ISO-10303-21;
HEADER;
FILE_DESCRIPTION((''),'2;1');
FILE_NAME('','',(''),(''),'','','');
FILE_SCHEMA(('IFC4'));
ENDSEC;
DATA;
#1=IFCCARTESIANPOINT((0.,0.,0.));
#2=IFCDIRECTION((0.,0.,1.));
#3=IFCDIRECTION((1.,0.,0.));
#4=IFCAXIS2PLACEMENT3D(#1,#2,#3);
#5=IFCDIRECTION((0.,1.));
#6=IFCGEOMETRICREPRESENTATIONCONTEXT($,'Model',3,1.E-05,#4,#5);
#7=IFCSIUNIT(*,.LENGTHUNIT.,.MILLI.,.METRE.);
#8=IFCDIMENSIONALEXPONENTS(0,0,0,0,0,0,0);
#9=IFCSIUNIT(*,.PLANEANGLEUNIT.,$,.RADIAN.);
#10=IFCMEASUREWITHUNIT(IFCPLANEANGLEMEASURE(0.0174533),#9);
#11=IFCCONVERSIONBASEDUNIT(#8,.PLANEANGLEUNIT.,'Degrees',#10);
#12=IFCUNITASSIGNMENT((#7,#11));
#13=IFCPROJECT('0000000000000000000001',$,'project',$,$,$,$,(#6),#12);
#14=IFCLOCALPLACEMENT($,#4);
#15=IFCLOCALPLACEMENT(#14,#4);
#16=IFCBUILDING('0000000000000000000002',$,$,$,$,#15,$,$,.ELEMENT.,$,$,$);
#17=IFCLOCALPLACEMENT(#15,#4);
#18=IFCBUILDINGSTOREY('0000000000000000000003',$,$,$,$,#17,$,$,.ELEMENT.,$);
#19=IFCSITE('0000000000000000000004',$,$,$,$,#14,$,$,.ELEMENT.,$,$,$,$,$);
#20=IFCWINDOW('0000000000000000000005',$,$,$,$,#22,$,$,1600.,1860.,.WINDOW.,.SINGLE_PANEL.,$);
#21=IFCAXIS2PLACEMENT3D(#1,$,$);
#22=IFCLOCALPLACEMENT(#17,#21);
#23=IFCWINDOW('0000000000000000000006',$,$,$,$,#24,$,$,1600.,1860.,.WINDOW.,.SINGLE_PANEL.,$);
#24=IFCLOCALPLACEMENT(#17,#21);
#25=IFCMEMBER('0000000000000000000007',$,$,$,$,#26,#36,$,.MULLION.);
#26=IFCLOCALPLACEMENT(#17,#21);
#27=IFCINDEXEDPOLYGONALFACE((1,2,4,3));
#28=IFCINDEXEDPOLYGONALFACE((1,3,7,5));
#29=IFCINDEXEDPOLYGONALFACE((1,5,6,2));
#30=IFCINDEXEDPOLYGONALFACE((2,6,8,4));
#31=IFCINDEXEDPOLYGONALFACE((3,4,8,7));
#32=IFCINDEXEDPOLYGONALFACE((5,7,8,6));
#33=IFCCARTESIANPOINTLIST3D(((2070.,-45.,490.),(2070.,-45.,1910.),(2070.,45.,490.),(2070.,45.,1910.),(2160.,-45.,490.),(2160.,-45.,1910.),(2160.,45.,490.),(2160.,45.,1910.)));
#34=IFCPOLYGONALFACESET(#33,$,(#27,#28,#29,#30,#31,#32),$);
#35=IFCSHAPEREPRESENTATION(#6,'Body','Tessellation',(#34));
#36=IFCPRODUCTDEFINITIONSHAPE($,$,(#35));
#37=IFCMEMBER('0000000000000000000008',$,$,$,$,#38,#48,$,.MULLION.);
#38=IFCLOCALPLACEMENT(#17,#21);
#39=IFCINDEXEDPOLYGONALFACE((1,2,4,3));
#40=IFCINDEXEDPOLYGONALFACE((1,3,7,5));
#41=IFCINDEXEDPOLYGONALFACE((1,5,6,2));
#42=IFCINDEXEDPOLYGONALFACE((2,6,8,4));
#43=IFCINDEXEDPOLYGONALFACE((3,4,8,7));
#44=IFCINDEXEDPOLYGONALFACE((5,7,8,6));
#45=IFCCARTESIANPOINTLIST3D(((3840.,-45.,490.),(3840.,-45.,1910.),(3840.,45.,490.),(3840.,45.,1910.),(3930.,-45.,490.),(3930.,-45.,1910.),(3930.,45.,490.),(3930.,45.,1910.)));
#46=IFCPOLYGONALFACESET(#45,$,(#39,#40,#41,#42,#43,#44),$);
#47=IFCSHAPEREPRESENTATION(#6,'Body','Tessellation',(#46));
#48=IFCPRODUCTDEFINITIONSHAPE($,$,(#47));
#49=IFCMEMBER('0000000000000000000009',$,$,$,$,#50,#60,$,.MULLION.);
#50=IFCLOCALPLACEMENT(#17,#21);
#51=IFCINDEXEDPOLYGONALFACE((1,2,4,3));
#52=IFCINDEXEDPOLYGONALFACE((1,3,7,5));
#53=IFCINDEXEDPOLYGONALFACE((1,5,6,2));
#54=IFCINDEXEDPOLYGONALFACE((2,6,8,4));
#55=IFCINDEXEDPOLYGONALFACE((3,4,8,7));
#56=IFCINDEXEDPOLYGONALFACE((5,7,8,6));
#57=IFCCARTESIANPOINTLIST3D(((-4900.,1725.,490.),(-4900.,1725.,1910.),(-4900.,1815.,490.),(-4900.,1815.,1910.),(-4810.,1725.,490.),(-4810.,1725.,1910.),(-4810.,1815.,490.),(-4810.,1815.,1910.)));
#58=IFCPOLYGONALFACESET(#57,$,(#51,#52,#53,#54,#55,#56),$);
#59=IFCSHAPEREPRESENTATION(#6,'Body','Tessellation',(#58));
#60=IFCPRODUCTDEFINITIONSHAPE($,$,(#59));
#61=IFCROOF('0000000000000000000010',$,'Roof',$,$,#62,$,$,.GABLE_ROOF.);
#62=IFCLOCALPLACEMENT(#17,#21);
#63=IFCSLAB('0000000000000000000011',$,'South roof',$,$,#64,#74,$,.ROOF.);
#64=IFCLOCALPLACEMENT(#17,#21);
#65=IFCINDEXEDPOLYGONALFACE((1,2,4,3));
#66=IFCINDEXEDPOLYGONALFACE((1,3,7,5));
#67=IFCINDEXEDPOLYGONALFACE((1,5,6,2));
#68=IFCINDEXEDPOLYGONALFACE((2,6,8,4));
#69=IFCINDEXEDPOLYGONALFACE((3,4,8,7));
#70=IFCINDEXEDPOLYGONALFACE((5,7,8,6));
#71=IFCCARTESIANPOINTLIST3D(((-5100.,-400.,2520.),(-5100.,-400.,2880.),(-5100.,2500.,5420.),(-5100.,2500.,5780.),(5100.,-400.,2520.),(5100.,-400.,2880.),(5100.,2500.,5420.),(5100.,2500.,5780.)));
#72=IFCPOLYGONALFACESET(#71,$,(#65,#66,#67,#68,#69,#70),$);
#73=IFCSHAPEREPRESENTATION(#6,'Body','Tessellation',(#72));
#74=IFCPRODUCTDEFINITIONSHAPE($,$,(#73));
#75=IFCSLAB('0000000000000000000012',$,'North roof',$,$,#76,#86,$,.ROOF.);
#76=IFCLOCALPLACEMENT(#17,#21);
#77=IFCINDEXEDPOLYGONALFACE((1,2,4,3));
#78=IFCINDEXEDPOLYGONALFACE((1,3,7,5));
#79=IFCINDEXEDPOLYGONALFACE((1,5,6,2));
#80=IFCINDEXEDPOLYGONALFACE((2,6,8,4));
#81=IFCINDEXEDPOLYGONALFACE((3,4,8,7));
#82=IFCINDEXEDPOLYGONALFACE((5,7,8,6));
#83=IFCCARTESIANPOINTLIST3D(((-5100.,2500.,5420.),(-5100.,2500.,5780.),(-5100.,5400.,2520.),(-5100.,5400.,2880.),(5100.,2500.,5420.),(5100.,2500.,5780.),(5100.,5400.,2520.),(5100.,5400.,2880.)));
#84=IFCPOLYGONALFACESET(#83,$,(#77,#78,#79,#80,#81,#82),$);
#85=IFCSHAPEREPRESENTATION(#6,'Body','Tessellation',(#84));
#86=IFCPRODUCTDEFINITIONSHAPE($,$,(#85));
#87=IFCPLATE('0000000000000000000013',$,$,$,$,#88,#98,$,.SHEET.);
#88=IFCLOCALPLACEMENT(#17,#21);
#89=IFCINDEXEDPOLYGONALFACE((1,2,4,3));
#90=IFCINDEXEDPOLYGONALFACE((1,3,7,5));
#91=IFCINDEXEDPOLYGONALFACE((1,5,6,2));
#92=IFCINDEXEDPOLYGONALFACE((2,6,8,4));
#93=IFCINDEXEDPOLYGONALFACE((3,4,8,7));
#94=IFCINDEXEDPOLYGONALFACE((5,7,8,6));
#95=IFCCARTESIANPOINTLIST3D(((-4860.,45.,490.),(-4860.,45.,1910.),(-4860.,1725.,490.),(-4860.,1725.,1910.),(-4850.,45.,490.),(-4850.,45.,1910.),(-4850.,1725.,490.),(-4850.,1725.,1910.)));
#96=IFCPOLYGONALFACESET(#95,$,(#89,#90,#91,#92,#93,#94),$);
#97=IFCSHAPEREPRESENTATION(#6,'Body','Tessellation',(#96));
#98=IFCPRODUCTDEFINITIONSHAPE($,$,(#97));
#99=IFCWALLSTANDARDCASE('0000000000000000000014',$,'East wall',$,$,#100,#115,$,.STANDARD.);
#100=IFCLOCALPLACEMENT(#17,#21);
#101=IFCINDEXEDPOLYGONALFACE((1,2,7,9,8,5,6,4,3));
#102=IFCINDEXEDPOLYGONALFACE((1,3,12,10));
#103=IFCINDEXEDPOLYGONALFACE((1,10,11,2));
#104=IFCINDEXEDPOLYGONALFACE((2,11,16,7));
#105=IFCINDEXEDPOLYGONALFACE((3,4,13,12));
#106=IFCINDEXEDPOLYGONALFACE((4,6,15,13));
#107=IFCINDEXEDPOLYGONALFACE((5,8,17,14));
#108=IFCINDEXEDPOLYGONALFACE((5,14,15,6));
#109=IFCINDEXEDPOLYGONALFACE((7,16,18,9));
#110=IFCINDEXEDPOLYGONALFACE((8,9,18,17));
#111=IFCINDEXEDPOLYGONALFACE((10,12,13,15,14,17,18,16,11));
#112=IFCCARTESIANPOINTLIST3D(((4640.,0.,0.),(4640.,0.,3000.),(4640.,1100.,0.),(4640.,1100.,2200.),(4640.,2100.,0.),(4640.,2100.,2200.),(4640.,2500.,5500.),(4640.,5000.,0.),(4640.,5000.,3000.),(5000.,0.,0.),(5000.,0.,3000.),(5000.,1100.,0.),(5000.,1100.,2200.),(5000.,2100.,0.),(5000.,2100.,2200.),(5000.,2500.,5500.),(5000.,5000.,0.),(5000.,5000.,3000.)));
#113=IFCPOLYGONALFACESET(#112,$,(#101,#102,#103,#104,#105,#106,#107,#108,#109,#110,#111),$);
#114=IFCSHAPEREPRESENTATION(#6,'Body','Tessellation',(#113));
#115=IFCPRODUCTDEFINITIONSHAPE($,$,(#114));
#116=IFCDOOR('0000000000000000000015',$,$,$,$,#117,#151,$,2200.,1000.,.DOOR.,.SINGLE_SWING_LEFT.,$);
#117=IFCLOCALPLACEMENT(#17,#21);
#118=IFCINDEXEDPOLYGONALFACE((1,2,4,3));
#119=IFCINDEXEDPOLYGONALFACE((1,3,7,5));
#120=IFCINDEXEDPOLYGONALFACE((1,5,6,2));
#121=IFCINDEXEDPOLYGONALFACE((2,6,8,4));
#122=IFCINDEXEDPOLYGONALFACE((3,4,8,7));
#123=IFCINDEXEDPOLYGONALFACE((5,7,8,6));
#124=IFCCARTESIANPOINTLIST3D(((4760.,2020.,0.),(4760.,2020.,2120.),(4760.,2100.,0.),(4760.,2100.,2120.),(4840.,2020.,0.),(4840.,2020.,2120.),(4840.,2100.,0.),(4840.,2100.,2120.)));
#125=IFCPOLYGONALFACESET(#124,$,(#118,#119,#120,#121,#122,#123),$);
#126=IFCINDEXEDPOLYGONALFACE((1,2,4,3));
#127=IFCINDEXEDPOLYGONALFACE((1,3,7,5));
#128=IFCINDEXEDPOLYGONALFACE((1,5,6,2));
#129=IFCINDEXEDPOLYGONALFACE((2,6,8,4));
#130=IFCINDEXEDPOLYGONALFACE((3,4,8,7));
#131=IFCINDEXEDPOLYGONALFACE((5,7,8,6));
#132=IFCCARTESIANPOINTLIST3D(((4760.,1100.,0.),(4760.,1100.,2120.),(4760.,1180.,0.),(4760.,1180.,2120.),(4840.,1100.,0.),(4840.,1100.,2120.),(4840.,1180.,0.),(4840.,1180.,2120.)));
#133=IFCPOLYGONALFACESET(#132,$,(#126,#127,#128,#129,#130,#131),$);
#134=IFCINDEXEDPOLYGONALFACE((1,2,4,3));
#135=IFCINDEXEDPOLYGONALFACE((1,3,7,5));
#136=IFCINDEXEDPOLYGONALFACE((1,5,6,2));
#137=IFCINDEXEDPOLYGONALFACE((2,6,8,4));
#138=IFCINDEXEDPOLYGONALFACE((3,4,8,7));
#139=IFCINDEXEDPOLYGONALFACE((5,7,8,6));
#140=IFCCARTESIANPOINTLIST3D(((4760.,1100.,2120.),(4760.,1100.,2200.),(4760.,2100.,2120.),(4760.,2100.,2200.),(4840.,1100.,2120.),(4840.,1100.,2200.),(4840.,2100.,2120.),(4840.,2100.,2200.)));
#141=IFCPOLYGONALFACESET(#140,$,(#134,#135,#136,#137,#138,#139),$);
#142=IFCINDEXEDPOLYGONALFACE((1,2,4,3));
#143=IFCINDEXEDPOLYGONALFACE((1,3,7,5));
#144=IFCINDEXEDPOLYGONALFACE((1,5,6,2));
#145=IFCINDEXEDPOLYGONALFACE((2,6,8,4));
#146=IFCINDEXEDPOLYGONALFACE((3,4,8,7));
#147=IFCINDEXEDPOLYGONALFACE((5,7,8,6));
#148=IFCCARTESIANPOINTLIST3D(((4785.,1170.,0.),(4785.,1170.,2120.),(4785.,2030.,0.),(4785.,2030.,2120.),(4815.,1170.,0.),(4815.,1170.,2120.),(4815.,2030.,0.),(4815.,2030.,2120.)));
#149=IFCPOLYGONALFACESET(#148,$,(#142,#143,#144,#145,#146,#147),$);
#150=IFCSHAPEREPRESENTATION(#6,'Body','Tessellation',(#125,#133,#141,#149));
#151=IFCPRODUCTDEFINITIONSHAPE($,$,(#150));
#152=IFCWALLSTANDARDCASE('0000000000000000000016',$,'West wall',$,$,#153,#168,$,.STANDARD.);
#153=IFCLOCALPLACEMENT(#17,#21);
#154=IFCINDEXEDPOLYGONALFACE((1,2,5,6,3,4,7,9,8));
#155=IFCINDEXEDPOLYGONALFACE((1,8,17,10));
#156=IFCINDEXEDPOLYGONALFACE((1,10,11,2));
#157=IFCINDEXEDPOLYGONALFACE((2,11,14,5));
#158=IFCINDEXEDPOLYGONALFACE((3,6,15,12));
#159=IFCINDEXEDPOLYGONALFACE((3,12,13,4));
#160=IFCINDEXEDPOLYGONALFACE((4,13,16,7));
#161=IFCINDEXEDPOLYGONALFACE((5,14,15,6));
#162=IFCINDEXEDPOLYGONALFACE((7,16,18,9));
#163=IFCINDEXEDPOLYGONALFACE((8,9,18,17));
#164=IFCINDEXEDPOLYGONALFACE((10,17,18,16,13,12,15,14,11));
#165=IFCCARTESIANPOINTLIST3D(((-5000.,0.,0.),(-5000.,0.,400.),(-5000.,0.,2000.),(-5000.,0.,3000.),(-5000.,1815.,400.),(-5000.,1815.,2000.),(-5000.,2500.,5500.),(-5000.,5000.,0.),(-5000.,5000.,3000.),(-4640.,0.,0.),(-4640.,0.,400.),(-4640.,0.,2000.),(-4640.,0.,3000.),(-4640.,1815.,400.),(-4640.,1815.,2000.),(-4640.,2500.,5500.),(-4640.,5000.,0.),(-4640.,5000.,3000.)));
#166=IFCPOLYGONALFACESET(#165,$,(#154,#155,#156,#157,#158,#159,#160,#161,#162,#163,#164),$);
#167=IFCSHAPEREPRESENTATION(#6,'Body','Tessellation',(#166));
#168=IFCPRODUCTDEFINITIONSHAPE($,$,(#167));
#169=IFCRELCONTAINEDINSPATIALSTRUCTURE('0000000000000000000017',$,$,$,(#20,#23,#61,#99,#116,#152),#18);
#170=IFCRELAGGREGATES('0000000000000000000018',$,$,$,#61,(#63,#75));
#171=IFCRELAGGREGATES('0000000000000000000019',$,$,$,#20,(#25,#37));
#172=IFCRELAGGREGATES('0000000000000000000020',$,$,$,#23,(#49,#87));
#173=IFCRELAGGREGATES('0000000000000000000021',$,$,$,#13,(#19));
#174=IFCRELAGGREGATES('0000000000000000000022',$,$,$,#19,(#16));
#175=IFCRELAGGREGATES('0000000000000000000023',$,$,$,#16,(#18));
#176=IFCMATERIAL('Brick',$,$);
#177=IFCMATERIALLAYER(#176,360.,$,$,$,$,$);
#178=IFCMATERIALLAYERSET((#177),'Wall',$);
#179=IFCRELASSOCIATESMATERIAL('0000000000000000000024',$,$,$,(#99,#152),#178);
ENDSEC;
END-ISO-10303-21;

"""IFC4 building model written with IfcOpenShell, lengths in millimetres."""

from ifc_helpers import new_model, entity, si_unit, converted_unit, direction, frame, origin_with_axes, place, context, project, spatial, polyline, outline, extrude, clip, halfspace, source, transform, mapped, material, layer, layer_set, layer_usage, element, fill, aggregate, save


model = new_model("IFC4")

# Units and contexts
model_context = context("Model", 3, precision=1e-05, world=origin_with_axes(), true_north=direction((0.0, 1.0)))
ifc_project = project(units=[si_unit("LENGTHUNIT", "METRE", prefix="MILLI"), converted_unit("PLANEANGLEUNIT", "Degrees", entity("IfcPlaneAngleMeasure", 0.0174533), si_unit("PLANEANGLEUNIT", "RADIAN"), dimensions=[0, 0, 0, 0, 0, 0, 0])], contexts=[model_context])

# Site, building, storey
site_placement = place(None, origin_with_axes())
site = spatial("IfcSite", under=ifc_project, at=site_placement, CompositionType="ELEMENT")
building_placement = place(site_placement, origin_with_axes())
building = spatial("IfcBuilding", under=site, at=building_placement, CompositionType="ELEMENT")
storey_placement = place(building_placement, origin_with_axes())
storey = spatial("IfcBuildingStorey", under=building, at=storey_placement, CompositionType="ELEMENT")

# Windows
window_1_placement = place(storey_placement, frame((2070.0, -45.0, 400.0), z_axis=(0.0, 0.0, 1.0), x_axis=(1.0, 0.0, 0.0)))
window_1 = element("IfcWindow", 1, at=window_1_placement, inside=storey, OverallHeight=1600.0, OverallWidth=1860.0, PartitioningType="SINGLE_PANEL", PredefinedType="WINDOW")
window_2_placement = place(storey_placement, frame((-4810.0, -45.0, 400.0), z_axis=(0.0, 0.0, 1.0), x_axis=(0.0, 1.0, 0.0)))
window_2 = element("IfcWindow", 2, at=window_2_placement, inside=storey, OverallHeight=1600.0, OverallWidth=1860.0, PartitioningType="SINGLE_PANEL", PredefinedType="WINDOW")

# Members
shared_shape_1 = source(origin_with_axes(), model_context, "Body", "SweptSolid", [
    extrude(outline(polyline([(-45.0, -45.0), (45.0, -45.0), (45.0, 45.0), (-45.0, 45.0), (-45.0, -45.0), (-45.0, -45.0)])), origin_with_axes(), (0.0, 0.0, 1.0), 1420.0),
])
member_1_placement = place(window_1_placement, frame((45.0, 45.0, 90.0), z_axis=(0.0, 0.0, 1.0), x_axis=(1.0, 0.0, 0.0)))
member_1 = element("IfcMember", 3, at=member_1_placement, PredefinedType="MULLION", context=model_context, shape_type="MappedRepresentation", body=[
    mapped(shared_shape_1, transform((0.0, 0.0, 0.0))),
])
member_2_placement = place(window_1_placement, frame((1815.0, 45.0, 90.0), z_axis=(0.0, 0.0, 1.0), x_axis=(1.0, 0.0, 0.0)))
member_2 = element("IfcMember", 4, at=member_2_placement, PredefinedType="MULLION", context=model_context, shape_type="MappedRepresentation", body=[
    mapped(shared_shape_1, transform((0.0, 0.0, 0.0))),
])
member_3_placement = place(window_2_placement, frame((1815.0, 45.0, 90.0), z_axis=(0.0, 0.0, 1.0), x_axis=(1.0, 0.0, 0.0)))
member_3 = element("IfcMember", 5, at=member_3_placement, PredefinedType="MULLION", context=model_context, shape_type="MappedRepresentation", body=[
    mapped(shared_shape_1, transform((0.0, 0.0, 0.0))),
])

# Roof, slabs
roof_placement = place(storey_placement, origin_with_axes())
roof = element("IfcRoof", 6, at=roof_placement, inside=storey, Name="Roof", PredefinedType="GABLE_ROOF")
shared_shape_2 = source(origin_with_axes(), model_context, "Body", "SweptSolid", [
    extrude(outline(polyline([(-5100.0, -180.0), (5100.0, -180.0), (5100.0, 180.0), (-5100.0, 180.0), (-5100.0, -180.0), (-5100.0, -180.0)])), frame((0.0, 0.0, 0.0), z_axis=(0.0, 1.0, 0.0), x_axis=(1.0, 0.0, 0.0)), (0.0, -0.707107, 0.707107), 4101.2),
])
slab_1_placement = place(roof_placement, frame((0.0, -400.0, 2700.0), z_axis=(0.0, 0.0, 1.0), x_axis=(1.0, 0.0, 0.0)))
slab_1 = element("IfcSlab", 7, at=slab_1_placement, Name="South roof", PredefinedType="ROOF", context=model_context, shape_type="MappedRepresentation", body=[
    mapped(shared_shape_2, transform((0.0, 0.0, 0.0))),
])
slab_2_placement = place(roof_placement, frame((0.0, 5400.0, 2700.0), z_axis=(0.0, 0.0, 1.0), x_axis=(-1.0, 0.0, 0.0)))
slab_2 = element("IfcSlab", 8, at=slab_2_placement, Name="North roof", PredefinedType="ROOF", context=model_context, shape_type="MappedRepresentation", body=[
    mapped(shared_shape_2, transform((0.0, 0.0, 0.0))),
])
aggregate(roof, [slab_1, slab_2])

# Plate
aggregate(window_1, [member_1, member_2])
plate_1_placement = place(window_2_placement, frame((930.0, 45.0, 90.0), z_axis=(0.0, 0.0, 1.0), x_axis=(1.0, 0.0, 0.0)))
plate_1 = element("IfcPlate", 9, at=plate_1_placement, PredefinedType="SHEET", context=model_context, shape_type="SweptSolid", body=[
    extrude(outline(polyline([(-840.0, -5.0), (840.0, -5.0), (840.0, 5.0), (-840.0, 5.0), (-840.0, -5.0), (-840.0, -5.0)])), origin_with_axes(), (0.0, 0.0, 1.0), 1420.0),
])
aggregate(window_2, [member_3, plate_1])

# Wall, opening, door
ifc_material = material(Name="Brick")
ifc_layer = layer(ifc_material, 360.0)
ifc_layer_set = layer_set([ifc_layer], Name="Wall")
ifc_layer_usage = layer_usage(ifc_layer_set, "AXIS2", "POSITIVE", -180.0)
shared_shape_3 = source(origin_with_axes(), model_context, "Body", "Clipping", [
    clip(clip(extrude(outline(polyline([(-2500.0, -180.0), (2500.0, -180.0), (2500.0, 180.0), (-2500.0, 180.0), (-2500.0, -180.0), (-2500.0, -180.0)])), origin_with_axes(), (0.0, 0.0, 1.0), 6000.0), halfspace(frame((-2500.0, 0.0, 3000.0), z_axis=(-1.0, 0.0, 1.0), x_axis=(1.0, 0.0, 0.0)), False)), halfspace(frame((2500.0, 0.0, 3000.0), z_axis=(1.0, 0.0, 1.0), x_axis=(1.0, 0.0, 0.0)), False)),
])
wall_1_placement = place(storey_placement, frame((4820.0, 2500.0, 0.0), z_axis=(0.0, 0.0, 1.0), x_axis=(0.0, 1.0, 0.0)))
wall_1 = element("IfcWallStandardCase", 10, at=wall_1_placement, inside=storey, material=ifc_layer_usage, Name="East wall", PredefinedType="STANDARD", context=model_context, shape_type="MappedRepresentation", body=[
    mapped(shared_shape_3, transform((0.0, 0.0, 0.0))),
])
opening_1_placement = place(storey_placement, frame((4820.0, 1600.0, 0.0), z_axis=(0.0, 0.0, 1.0), x_axis=(1.0, 0.0, 0.0)))
opening_1 = element("IfcOpeningElement", 11, at=opening_1_placement, cuts=wall_1, PredefinedType="OPENING", context=model_context, shape_type="SweptSolid", body=[
    extrude(outline(polyline([(-500.0, -500.0), (500.0, -500.0), (500.0, 500.0), (-500.0, 500.0), (-500.0, -500.0), (-500.0, -500.0)])), origin_with_axes(), (0.0, 0.0, 1.0), 2200.0),
])
door_placement = place(storey_placement, frame((4800.0, 1600.0, 0.0), z_axis=(0.0, 0.0, 1.0), x_axis=(0.0, 1.0, 0.0)))
door = element("IfcDoor", 12, at=door_placement, inside=storey, OperationType="SINGLE_SWING_LEFT", OverallHeight=2200.0, OverallWidth=1000.0, PredefinedType="DOOR", context=model_context, shape_type="SweptSolid", body=[
    extrude(outline(polyline([(-40.0, -40.0), (40.0, -40.0), (40.0, 40.0), (-40.0, 40.0), (-40.0, -40.0), (-40.0, -40.0)])), frame((460.0, 0.0, 0.0), z_axis=(0.0, 0.0, 1.0), x_axis=(1.0, 0.0, 0.0)), (0.0, 0.0, 1.0), 2120.0),
    extrude(outline(polyline([(-40.0, -40.0), (40.0, -40.0), (40.0, 40.0), (-40.0, 40.0), (-40.0, -40.0), (-40.0, -40.0)])), frame((-460.0, 0.0, 0.0), z_axis=(0.0, 0.0, 1.0), x_axis=(1.0, 0.0, 0.0)), (0.0, 0.0, 1.0), 2120.0),
    extrude(outline(polyline([(-500.0, -40.0), (500.0, -40.0), (500.0, 40.0), (-500.0, 40.0), (-500.0, -40.0), (-500.0, -40.0)])), frame((0.0, 0.0, 2120.0), z_axis=(0.0, 0.0, 1.0), x_axis=(1.0, 0.0, 0.0)), (0.0, 0.0, 1.0), 80.0),
    extrude(outline(polyline([(-430.0, -15.0), (430.0, -15.0), (430.0, 15.0), (-430.0, 15.0), (-430.0, -15.0), (-430.0, -15.0)])), origin_with_axes(), (0.0, 0.0, 1.0), 2120.0),
])
fill(opening_1, door)

# Wall, opening
wall_2_placement = place(storey_placement, frame((-4820.0, 2500.0, 0.0), z_axis=(0.0, 0.0, 1.0), x_axis=(0.0, -1.0, 0.0)))
wall_2 = element("IfcWallStandardCase", 13, at=wall_2_placement, inside=storey, material=ifc_layer_usage, Name="West wall", PredefinedType="STANDARD", context=model_context, shape_type="MappedRepresentation", body=[
    mapped(shared_shape_3, transform((0.0, 0.0, 0.0))),
])
opening_2_placement = place(wall_2_placement, frame((2500.0, 2320.0, 400.0), z_axis=(0.0, 0.0, 1.0), x_axis=(0.0, 1.0, 0.0)))
element("IfcOpeningElement", 14, at=opening_2_placement, cuts=wall_2, PredefinedType="OPENING", context=model_context, shape_type="SweptSolid", body=[
    extrude(outline(polyline([(-3000.0, -1815.0), (3000.0, -1815.0), (3000.0, 1815.0), (-3000.0, 1815.0), (-3000.0, -1815.0), (-3000.0, -1815.0)])), origin_with_axes(), (0.0, 0.0, 1.0), 1600.0),
])

save(model, "model.ifc")
